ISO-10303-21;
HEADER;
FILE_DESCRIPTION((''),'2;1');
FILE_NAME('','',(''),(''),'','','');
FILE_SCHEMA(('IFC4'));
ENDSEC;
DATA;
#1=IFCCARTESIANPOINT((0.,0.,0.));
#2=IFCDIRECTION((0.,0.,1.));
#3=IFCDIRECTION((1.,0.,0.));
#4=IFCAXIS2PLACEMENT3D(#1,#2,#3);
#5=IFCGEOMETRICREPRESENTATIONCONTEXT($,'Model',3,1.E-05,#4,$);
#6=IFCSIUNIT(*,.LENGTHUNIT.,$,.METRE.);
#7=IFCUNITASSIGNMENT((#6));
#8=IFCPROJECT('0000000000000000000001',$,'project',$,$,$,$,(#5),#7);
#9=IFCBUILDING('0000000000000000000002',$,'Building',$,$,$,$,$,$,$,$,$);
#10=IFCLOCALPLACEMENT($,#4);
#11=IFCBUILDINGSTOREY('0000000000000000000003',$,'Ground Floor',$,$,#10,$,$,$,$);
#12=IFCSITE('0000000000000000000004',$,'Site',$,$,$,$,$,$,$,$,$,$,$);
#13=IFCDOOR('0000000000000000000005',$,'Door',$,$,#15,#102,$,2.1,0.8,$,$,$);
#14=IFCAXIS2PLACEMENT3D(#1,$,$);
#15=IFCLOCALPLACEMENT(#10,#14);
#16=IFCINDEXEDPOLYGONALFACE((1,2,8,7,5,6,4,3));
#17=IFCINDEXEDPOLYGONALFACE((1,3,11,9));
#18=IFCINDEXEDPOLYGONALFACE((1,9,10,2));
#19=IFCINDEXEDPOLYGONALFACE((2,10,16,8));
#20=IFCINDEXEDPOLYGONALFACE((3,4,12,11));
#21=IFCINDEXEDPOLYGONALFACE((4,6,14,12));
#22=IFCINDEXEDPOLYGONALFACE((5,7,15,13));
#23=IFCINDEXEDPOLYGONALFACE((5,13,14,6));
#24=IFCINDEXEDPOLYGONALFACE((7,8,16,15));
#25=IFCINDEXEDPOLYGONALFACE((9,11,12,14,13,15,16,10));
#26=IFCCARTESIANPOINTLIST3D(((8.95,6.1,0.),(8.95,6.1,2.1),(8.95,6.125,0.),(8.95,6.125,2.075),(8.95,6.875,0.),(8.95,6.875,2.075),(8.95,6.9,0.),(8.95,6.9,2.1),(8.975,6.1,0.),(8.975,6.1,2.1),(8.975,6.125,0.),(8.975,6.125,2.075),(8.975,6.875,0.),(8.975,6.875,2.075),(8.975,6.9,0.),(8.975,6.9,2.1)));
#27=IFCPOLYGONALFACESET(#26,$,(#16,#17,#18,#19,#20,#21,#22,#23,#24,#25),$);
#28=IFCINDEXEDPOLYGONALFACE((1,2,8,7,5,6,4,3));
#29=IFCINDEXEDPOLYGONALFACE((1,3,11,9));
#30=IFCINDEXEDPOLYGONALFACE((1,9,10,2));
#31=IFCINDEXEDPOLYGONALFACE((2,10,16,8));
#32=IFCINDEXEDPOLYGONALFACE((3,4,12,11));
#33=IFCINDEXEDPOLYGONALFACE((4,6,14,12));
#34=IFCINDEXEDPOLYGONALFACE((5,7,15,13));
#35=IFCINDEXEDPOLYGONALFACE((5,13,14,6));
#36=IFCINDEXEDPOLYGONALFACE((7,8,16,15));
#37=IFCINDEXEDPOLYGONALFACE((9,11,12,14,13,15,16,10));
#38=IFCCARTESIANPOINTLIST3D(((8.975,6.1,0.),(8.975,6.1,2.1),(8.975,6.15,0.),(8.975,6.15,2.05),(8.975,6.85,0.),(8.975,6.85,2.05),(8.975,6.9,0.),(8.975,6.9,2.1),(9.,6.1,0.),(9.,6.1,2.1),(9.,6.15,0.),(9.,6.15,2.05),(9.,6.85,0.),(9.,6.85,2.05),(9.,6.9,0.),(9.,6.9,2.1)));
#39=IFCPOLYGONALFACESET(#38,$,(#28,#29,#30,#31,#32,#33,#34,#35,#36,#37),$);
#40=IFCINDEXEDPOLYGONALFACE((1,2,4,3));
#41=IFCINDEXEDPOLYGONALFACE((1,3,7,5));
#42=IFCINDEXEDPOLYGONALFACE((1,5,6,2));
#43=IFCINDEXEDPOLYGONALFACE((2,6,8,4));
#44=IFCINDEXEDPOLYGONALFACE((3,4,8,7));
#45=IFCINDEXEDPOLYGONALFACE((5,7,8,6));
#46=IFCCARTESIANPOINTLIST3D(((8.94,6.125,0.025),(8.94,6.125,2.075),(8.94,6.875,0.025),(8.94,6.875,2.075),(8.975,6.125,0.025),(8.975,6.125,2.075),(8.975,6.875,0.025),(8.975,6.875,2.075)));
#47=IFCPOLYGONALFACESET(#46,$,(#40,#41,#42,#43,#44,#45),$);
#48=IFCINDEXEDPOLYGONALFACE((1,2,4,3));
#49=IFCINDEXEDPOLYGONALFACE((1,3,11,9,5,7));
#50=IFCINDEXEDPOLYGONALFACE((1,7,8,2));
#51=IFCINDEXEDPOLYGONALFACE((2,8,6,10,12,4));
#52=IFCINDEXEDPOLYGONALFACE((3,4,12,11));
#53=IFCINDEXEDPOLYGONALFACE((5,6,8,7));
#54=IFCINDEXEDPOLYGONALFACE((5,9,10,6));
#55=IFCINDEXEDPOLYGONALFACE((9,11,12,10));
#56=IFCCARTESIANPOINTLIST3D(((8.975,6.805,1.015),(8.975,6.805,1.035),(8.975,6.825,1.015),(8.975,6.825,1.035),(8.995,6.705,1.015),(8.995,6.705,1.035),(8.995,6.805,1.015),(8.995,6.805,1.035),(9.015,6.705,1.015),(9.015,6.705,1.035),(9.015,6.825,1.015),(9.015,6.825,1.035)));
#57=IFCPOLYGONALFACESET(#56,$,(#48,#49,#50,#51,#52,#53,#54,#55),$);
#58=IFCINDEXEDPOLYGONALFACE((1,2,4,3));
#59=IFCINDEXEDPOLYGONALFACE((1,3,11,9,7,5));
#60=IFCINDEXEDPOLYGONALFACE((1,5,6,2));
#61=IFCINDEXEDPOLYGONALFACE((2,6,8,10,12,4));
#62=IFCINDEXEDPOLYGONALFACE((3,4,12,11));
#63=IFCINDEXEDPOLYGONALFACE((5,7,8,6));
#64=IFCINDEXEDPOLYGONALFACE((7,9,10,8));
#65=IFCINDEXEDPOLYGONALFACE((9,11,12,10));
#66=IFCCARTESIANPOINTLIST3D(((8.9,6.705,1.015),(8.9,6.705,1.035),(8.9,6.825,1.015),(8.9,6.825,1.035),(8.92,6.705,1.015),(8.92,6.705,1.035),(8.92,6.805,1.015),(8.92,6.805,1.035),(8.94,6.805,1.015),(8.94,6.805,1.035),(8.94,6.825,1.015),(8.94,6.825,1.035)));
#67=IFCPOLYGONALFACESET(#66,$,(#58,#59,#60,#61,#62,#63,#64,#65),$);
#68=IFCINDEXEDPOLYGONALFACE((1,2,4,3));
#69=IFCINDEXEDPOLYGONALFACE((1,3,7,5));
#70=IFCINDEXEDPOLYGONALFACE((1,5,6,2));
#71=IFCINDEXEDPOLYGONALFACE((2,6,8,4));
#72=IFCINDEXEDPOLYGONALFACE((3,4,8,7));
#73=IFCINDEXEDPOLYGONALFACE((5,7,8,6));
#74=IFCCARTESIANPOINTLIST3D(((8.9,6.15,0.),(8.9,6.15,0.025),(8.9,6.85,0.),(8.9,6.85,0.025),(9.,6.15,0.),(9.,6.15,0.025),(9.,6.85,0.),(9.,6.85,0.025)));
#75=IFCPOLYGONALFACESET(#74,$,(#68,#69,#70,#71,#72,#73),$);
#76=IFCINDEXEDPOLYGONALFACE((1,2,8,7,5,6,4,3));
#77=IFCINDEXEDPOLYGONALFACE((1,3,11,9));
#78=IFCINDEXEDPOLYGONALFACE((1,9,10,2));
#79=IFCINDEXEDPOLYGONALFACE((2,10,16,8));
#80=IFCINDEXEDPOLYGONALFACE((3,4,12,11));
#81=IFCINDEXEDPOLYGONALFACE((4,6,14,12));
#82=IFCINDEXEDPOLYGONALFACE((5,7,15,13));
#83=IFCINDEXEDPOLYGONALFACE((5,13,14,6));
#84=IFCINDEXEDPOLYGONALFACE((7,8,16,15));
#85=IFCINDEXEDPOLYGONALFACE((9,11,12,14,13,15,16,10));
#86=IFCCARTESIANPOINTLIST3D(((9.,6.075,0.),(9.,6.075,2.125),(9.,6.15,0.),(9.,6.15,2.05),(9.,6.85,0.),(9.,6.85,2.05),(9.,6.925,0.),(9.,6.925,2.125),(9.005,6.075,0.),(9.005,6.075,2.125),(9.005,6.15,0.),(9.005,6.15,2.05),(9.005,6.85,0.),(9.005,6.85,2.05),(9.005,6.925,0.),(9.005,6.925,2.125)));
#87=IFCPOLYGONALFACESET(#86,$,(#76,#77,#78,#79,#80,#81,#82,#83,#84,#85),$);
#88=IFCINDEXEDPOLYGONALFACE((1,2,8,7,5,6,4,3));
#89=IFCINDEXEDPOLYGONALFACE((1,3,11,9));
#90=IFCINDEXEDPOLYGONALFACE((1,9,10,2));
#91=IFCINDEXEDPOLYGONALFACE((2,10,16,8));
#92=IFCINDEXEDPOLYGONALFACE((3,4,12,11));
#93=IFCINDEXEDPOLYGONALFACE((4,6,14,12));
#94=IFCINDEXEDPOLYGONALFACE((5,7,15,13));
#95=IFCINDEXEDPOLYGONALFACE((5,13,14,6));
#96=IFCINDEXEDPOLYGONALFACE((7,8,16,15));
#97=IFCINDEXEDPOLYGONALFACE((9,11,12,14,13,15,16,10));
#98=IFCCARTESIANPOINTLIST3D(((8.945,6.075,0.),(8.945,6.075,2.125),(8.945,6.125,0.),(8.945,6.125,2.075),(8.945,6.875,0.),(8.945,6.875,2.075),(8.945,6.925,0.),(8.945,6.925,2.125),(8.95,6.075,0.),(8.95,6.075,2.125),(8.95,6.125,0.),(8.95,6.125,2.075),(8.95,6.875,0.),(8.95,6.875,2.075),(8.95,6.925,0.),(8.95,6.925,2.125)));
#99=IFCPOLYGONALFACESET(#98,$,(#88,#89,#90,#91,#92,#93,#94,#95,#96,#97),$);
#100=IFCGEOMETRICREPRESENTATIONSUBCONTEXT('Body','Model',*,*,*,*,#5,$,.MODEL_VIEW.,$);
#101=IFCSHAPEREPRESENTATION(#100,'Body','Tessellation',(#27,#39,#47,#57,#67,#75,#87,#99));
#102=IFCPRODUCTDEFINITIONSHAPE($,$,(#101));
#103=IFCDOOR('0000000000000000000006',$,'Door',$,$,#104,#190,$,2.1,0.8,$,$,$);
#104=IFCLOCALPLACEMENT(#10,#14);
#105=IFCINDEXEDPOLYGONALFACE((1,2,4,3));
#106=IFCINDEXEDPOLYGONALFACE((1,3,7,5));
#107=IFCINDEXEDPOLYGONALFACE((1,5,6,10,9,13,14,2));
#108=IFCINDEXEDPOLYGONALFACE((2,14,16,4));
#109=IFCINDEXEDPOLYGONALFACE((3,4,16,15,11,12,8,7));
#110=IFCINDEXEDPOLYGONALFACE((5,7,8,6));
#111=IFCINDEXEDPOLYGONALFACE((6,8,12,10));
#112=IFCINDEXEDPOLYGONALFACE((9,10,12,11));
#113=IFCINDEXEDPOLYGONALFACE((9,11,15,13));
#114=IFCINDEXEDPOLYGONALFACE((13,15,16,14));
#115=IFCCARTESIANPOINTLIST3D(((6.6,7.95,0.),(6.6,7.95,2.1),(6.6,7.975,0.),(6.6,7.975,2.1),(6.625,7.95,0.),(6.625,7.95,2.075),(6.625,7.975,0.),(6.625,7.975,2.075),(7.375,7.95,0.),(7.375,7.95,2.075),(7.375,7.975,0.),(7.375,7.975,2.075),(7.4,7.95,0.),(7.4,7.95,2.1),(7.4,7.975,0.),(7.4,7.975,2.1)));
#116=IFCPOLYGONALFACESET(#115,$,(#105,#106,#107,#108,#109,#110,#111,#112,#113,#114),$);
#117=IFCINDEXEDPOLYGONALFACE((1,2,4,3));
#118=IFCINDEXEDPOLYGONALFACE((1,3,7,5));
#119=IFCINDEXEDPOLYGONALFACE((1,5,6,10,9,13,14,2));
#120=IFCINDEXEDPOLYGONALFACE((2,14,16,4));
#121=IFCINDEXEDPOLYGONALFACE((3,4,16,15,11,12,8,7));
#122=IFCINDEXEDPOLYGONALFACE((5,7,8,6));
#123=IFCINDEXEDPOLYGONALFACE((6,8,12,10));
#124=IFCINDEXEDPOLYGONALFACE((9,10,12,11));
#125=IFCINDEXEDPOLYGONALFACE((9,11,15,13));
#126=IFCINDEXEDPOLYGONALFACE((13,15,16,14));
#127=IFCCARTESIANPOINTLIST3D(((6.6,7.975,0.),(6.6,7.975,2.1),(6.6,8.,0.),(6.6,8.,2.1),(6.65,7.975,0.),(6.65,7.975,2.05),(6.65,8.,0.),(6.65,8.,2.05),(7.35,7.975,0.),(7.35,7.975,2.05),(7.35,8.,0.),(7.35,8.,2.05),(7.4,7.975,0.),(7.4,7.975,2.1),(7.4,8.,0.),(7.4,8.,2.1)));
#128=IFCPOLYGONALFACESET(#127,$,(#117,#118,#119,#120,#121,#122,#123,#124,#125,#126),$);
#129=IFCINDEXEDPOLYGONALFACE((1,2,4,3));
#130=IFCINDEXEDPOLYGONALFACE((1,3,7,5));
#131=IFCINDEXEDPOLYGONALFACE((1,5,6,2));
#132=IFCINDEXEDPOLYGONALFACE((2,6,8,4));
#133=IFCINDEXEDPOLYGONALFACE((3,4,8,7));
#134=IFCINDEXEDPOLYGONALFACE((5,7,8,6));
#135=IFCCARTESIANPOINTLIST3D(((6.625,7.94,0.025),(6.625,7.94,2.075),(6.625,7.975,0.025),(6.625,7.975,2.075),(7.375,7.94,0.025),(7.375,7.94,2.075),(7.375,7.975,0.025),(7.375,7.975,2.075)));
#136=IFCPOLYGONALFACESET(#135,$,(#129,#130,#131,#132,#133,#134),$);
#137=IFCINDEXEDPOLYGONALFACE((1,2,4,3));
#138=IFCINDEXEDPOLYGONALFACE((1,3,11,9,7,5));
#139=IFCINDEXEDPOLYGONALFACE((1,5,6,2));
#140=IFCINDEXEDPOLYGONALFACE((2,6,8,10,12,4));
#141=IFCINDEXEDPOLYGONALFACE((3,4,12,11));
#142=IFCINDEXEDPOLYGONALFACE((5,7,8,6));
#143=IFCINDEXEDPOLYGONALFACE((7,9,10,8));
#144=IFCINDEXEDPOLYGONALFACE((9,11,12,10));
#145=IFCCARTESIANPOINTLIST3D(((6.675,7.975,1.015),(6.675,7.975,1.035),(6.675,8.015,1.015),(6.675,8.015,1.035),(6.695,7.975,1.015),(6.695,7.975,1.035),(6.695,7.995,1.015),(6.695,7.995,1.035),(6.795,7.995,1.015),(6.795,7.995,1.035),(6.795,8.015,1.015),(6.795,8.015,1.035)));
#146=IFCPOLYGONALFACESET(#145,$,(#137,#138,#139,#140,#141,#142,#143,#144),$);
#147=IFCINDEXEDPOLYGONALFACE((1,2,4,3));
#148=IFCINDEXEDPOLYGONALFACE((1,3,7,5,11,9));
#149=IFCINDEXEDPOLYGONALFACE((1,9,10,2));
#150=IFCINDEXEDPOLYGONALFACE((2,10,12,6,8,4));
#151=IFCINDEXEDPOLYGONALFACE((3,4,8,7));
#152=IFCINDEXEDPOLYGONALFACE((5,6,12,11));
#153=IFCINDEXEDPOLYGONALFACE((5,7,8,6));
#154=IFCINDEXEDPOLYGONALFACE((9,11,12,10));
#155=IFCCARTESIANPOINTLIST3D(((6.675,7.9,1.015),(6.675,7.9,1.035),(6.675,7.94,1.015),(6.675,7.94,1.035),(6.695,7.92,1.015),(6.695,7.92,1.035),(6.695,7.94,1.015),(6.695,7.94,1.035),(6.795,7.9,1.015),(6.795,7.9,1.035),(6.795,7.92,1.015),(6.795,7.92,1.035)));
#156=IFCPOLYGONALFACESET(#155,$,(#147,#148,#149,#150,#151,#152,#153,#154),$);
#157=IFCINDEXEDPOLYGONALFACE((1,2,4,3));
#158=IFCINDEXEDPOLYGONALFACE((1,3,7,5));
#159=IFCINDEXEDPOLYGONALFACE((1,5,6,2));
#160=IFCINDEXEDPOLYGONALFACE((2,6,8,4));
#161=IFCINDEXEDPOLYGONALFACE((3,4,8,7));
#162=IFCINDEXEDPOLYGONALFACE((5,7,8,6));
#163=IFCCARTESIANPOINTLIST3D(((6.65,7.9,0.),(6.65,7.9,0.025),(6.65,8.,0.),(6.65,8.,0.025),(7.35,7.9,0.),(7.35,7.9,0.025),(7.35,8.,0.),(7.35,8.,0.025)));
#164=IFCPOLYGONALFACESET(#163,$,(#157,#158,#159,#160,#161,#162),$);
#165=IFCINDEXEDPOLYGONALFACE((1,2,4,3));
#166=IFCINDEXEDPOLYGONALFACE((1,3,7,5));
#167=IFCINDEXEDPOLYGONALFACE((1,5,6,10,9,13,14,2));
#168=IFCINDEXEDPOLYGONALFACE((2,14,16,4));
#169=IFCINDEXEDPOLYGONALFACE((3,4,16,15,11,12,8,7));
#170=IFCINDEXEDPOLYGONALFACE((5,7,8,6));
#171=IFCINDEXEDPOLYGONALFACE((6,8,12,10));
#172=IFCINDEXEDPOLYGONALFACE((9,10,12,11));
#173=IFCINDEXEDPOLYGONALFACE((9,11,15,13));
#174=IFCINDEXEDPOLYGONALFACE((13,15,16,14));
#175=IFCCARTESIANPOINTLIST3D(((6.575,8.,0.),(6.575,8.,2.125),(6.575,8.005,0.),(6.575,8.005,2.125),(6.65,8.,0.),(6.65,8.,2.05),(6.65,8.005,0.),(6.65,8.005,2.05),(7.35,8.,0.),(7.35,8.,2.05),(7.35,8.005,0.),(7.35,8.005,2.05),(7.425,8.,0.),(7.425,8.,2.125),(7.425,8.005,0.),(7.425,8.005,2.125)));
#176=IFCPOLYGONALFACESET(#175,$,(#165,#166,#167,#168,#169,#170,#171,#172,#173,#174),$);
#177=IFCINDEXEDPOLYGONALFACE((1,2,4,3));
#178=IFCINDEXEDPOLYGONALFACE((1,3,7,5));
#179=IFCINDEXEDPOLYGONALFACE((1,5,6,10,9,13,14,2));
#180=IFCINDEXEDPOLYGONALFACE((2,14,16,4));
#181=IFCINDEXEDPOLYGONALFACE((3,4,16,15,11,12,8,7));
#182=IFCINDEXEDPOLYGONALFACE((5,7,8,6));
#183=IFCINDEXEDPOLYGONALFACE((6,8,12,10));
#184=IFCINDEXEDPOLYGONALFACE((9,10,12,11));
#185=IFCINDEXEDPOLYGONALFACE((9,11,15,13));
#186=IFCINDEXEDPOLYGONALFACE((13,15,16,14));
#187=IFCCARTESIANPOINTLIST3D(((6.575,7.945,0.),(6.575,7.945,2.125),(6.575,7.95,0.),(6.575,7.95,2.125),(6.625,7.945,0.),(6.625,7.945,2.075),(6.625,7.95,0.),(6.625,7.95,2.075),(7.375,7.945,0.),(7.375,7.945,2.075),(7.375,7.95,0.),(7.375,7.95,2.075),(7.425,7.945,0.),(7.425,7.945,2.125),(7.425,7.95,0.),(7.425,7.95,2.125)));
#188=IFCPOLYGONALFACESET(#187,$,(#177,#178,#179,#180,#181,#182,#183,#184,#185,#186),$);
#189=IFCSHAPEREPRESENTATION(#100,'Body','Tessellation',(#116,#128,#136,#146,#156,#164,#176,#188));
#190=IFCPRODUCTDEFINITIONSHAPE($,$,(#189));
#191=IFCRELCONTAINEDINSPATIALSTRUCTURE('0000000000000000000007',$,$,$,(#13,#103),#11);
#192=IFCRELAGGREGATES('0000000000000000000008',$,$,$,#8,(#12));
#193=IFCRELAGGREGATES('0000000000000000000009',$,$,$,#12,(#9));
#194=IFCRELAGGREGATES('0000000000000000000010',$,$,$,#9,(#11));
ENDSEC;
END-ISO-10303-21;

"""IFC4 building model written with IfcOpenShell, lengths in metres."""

from ifc_helpers import new_model, si_unit, frame, origin_with_axes, place, context, subcontext, project, spatial, line, indexed_curve, outline, extrude, element, save


model = new_model("IFC4")

# Units and contexts
model_context = context("Model", 3, precision=1e-05, world=origin_with_axes())
body_context = subcontext(model_context, "Body", "Model", "MODEL_VIEW")
ifc_project = project(units=[si_unit("LENGTHUNIT", "METRE")], contexts=[model_context])

# Site, building, storey
site = spatial("IfcSite", under=ifc_project, Name="Site")
building = spatial("IfcBuilding", under=site, Name="Building")
storey_placement = place(None, origin_with_axes())
storey = spatial("IfcBuildingStorey", under=building, at=storey_placement, Name="Ground Floor")

# Doors
door_1_placement = place(storey_placement, frame((9.0, 6.1, 0.0), z_axis=(0.0, 0.0, 1.0), x_axis=(0.0, 1.0, 0.0)))
element("IfcDoor", 1, at=door_1_placement, inside=storey, Name="Door", OverallHeight=2.1, OverallWidth=0.8, context=body_context, shape_type="SweptSolid", body=[
    extrude(outline(indexed_curve([(0.0, 0.0), (0.0, 2.1), (0.8, 2.1), (0.8, 0.0), (0.775, 0.0), (0.775, 2.075), (0.025, 2.075), (0.025, 0.0)], segments=[line(1, 2, 3, 4, 5, 6, 7, 8, 1)])), frame((0.0, 0.025, 0.0), z_axis=(0.0, -1.0, 0.0), x_axis=(1.0, 0.0, 0.0)), (0.0, 0.0, -1.0), 0.025),
    extrude(outline(indexed_curve([(0.0, 0.0), (0.0, 2.1), (0.8, 2.1), (0.8, 0.0), (0.75, 0.0), (0.75, 2.05), (0.05, 2.05), (0.05, 0.0)], segments=[line(1, 2, 3, 4, 5, 6, 7, 8, 1)])), frame((0.0, 0.0, 0.0), z_axis=(0.0, -1.0, 0.0), x_axis=(1.0, 0.0, 0.0)), (0.0, 0.0, -1.0), 0.025),
    extrude(outline(indexed_curve([(0.0, 0.0), (0.75, 0.0), (0.75, 0.035), (0.0, 0.035)], segments=[line(1, 2, 3, 4, 1)])), frame((0.025, 0.025, 0.025), z_axis=(0.0, 0.0, 1.0), x_axis=(1.0, 0.0, 0.0)), (0.0, 0.0, 1.0), 2.05),
    extrude(outline(indexed_curve([(0.0, 0.0), (0.0, -0.04), (-0.12, -0.04), (-0.12, -0.02), (-0.02, -0.02), (-0.02, 0.0)], segments=[line(1, 2, 3, 4, 5, 6, 1)])), frame((0.725, 0.025, 1.015), z_axis=(0.0, 0.0, 1.0), x_axis=(1.0, 0.0, 0.0)), (0.0, 0.0, 1.0), 0.02),
    extrude(outline(indexed_curve([(0.0, 0.0), (0.0, 0.04), (-0.12, 0.04), (-0.12, 0.02), (-0.02, 0.02), (-0.02, 0.0)], segments=[line(1, 2, 3, 4, 5, 6, 1)])), frame((0.725, 0.06, 1.015), z_axis=(0.0, 0.0, 1.0), x_axis=(1.0, 0.0, 0.0)), (0.0, 0.0, 1.0), 0.02),
    extrude(outline(indexed_curve([(0.0, 0.0), (0.7, 0.0), (0.7, 0.1), (0.0, 0.1)], segments=[line(1, 2, 3, 4, 1)])), frame((0.05, 0.0, 0.0), z_axis=(0.0, 0.0, 1.0), x_axis=(1.0, 0.0, 0.0)), (0.0, 0.0, 1.0), 0.025),
    extrude(outline(indexed_curve([(0.0, 0.0), (0.0, 2.125), (0.85, 2.125), (0.85, 0.0), (0.775, 0.0), (0.775, 2.05), (0.075, 2.05), (0.075, 0.0)], segments=[line(1, 2, 3, 4, 5, 6, 7, 8, 1)])), frame((-0.025, -0.005, 0.0), z_axis=(0.0, -1.0, 0.0), x_axis=(1.0, 0.0, 0.0)), (0.0, 0.0, -1.0), 0.005),
    extrude(outline(indexed_curve([(0.0, 0.0), (0.0, 2.125), (0.85, 2.125), (0.85, 0.0), (0.8, 0.0), (0.8, 2.075), (0.05, 2.075), (0.05, 0.0)], segments=[line(1, 2, 3, 4, 5, 6, 7, 8, 1)])), frame((-0.025, 0.05, 0.0), z_axis=(0.0, -1.0, 0.0), x_axis=(1.0, 0.0, 0.0)), (0.0, 0.0, -1.0), 0.005),
])
door_2_placement = place(storey_placement, frame((7.4, 8.0, 0.0), z_axis=(0.0, 0.0, 1.0), x_axis=(-1.0, 0.0, 0.0)))
element("IfcDoor", 2, at=door_2_placement, inside=storey, Name="Door", OverallHeight=2.1, OverallWidth=0.8, context=body_context, shape_type="SweptSolid", body=[
    extrude(outline(indexed_curve([(0.0, 0.0), (0.0, 2.1), (0.8, 2.1), (0.8, 0.0), (0.775, 0.0), (0.775, 2.075), (0.025, 2.075), (0.025, 0.0)], segments=[line(1, 2, 3, 4, 5, 6, 7, 8, 1)])), frame((0.0, 0.025, 0.0), z_axis=(0.0, -1.0, 0.0), x_axis=(1.0, 0.0, 0.0)), (0.0, 0.0, -1.0), 0.025),
    extrude(outline(indexed_curve([(0.0, 0.0), (0.0, 2.1), (0.8, 2.1), (0.8, 0.0), (0.75, 0.0), (0.75, 2.05), (0.05, 2.05), (0.05, 0.0)], segments=[line(1, 2, 3, 4, 5, 6, 7, 8, 1)])), frame((0.0, 0.0, 0.0), z_axis=(0.0, -1.0, 0.0), x_axis=(1.0, 0.0, 0.0)), (0.0, 0.0, -1.0), 0.025),
    extrude(outline(indexed_curve([(0.0, 0.0), (0.75, 0.0), (0.75, 0.035), (0.0, 0.035)], segments=[line(1, 2, 3, 4, 1)])), frame((0.025, 0.025, 0.025), z_axis=(0.0, 0.0, 1.0), x_axis=(1.0, 0.0, 0.0)), (0.0, 0.0, 1.0), 2.05),
    extrude(outline(indexed_curve([(0.0, 0.0), (0.0, -0.04), (-0.12, -0.04), (-0.12, -0.02), (-0.02, -0.02), (-0.02, 0.0)], segments=[line(1, 2, 3, 4, 5, 6, 1)])), frame((0.725, 0.025, 1.015), z_axis=(0.0, 0.0, 1.0), x_axis=(1.0, 0.0, 0.0)), (0.0, 0.0, 1.0), 0.02),
    extrude(outline(indexed_curve([(0.0, 0.0), (0.0, 0.04), (-0.12, 0.04), (-0.12, 0.02), (-0.02, 0.02), (-0.02, 0.0)], segments=[line(1, 2, 3, 4, 5, 6, 1)])), frame((0.725, 0.06, 1.015), z_axis=(0.0, 0.0, 1.0), x_axis=(1.0, 0.0, 0.0)), (0.0, 0.0, 1.0), 0.02),
    extrude(outline(indexed_curve([(0.0, 0.0), (0.7, 0.0), (0.7, 0.1), (0.0, 0.1)], segments=[line(1, 2, 3, 4, 1)])), frame((0.05, 0.0, 0.0), z_axis=(0.0, 0.0, 1.0), x_axis=(1.0, 0.0, 0.0)), (0.0, 0.0, 1.0), 0.025),
    extrude(outline(indexed_curve([(0.0, 0.0), (0.0, 2.125), (0.85, 2.125), (0.85, 0.0), (0.775, 0.0), (0.775, 2.05), (0.075, 2.05), (0.075, 0.0)], segments=[line(1, 2, 3, 4, 5, 6, 7, 8, 1)])), frame((-0.025, -0.005, 0.0), z_axis=(0.0, -1.0, 0.0), x_axis=(1.0, 0.0, 0.0)), (0.0, 0.0, -1.0), 0.005),
    extrude(outline(indexed_curve([(0.0, 0.0), (0.0, 2.125), (0.85, 2.125), (0.85, 0.0), (0.8, 0.0), (0.8, 2.075), (0.05, 2.075), (0.05, 0.0)], segments=[line(1, 2, 3, 4, 5, 6, 7, 8, 1)])), frame((-0.025, 0.05, 0.0), z_axis=(0.0, -1.0, 0.0), x_axis=(1.0, 0.0, 0.0)), (0.0, 0.0, -1.0), 0.005),
])

save(model, "model.ifc")
